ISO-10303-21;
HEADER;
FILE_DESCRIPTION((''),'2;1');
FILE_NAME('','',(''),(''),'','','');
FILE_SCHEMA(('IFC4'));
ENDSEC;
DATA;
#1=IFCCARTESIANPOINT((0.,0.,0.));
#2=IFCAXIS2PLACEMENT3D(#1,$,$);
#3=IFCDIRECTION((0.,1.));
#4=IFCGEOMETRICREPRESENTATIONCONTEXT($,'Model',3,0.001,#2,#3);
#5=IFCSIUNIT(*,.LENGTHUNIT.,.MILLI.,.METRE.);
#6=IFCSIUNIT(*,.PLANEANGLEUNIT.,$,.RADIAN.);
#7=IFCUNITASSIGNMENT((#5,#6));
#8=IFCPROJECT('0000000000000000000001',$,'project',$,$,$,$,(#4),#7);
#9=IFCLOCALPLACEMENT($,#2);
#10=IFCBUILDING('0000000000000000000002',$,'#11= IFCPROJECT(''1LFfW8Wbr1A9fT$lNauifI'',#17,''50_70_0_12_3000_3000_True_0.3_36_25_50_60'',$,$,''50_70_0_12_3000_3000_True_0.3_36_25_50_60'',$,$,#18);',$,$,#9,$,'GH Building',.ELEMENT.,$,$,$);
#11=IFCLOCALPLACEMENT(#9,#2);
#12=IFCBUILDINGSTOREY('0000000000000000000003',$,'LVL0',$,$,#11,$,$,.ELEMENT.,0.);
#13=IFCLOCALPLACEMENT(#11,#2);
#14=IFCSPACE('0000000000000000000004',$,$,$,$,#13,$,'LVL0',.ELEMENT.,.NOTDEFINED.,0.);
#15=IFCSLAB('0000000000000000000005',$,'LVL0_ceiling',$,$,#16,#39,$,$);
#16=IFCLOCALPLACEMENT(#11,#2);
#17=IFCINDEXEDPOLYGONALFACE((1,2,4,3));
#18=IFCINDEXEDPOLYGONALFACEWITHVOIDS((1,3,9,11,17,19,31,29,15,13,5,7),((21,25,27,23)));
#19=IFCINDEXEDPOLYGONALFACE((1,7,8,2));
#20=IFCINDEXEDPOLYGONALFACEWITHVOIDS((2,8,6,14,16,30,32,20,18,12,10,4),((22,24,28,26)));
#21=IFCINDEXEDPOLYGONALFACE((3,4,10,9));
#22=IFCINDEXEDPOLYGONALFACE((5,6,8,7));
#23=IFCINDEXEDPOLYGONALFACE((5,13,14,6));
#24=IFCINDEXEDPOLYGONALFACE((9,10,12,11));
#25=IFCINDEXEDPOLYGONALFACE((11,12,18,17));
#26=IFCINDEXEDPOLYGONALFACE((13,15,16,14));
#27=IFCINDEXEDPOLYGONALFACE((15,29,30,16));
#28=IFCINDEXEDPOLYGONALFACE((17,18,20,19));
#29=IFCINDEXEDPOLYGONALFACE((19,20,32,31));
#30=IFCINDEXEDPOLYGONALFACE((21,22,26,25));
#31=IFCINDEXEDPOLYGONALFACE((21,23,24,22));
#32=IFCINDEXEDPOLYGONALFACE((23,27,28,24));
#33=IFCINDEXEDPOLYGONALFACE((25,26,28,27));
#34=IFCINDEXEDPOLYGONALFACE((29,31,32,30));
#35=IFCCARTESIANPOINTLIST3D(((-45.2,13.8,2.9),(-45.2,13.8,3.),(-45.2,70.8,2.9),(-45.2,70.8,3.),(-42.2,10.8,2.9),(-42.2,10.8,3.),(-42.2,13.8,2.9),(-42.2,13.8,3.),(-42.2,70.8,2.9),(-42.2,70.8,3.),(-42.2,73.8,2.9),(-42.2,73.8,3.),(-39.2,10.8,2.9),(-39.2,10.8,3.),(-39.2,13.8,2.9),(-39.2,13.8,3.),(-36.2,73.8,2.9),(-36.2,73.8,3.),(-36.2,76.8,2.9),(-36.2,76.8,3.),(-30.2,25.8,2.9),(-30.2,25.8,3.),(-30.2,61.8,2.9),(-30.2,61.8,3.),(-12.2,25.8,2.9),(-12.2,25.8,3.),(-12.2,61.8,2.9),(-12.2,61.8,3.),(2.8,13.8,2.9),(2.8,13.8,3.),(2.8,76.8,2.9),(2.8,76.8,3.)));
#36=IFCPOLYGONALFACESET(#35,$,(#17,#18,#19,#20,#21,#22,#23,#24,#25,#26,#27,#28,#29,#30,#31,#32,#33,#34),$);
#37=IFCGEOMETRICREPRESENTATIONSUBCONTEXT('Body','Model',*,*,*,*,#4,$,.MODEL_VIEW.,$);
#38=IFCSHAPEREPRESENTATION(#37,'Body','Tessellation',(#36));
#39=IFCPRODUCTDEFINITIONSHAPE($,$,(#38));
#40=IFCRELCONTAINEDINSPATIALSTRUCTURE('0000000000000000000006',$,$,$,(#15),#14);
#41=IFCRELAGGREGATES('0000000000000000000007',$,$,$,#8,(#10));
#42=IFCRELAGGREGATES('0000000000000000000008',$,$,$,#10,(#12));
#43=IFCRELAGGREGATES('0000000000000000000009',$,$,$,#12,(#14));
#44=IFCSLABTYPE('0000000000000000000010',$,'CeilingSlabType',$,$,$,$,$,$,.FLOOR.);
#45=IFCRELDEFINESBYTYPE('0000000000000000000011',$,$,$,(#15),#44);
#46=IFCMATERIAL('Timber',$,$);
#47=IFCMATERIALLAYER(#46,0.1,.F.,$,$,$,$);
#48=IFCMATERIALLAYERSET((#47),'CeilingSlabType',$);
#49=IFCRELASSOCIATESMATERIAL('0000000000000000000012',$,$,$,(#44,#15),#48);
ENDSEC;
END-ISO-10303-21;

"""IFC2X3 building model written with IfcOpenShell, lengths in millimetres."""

from ifc_helpers import new_model, si_unit, direction, frame, origin, place, context, subcontext, project, spatial, polyline, outline, extrude, material, layer, layer_set, layer_usage, type_object, element, save


model = new_model("IFC2X3")

# Units and contexts
model_context = context("Model", 3, precision=0.001, world=origin(), true_north=direction((0.0, 1.0)))
body_context = subcontext(model_context, "Body", "Model", "MODEL_VIEW")
ifc_project = project(units=[si_unit("LENGTHUNIT", "METRE", prefix="MILLI"), si_unit("PLANEANGLEUNIT", "RADIAN")], contexts=[model_context])

# Building, storey, space
building_placement = place(None, origin())
building = spatial("IfcBuilding", under=ifc_project, at=building_placement, Name="#11= IFCPROJECT('1LFfW8Wbr1A9fT$lNauifI',#17,'50_70_0_12_3000_3000_True_0.3_36_25_50_60',$,$,'50_70_0_12_3000_3000_True_0.3_36_25_50_60',$,$,#18);", LongName="GH Building", CompositionType="ELEMENT")
storey_placement = place(building_placement, origin())
storey = spatial("IfcBuildingStorey", under=building, at=storey_placement, Name="LVL0", CompositionType="ELEMENT", Elevation=0.0)
space_placement = place(storey_placement, origin())
space = spatial("IfcSpace", under=storey, at=space_placement, LongName="LVL0", CompositionType="ELEMENT", InteriorOrExteriorSpace="NOTDEFINED", ElevationWithFlooring=0.0)

# Slab
ifc_material_1 = material(Name="Timber")
ifc_layer_1 = layer(ifc_material_1, 0.1, ventilated=False)
ifc_layer_set_1 = layer_set([ifc_layer_1], Name="CeilingSlabType")
ifc_layer_usage_1 = layer_usage(ifc_layer_set_1, "AXIS3", "NEGATIVE", -0.1)
slab_type = type_object("IfcSlabType", Name="CeilingSlabType", PredefinedType="FLOOR", material=ifc_layer_set_1)
slab_placement = place(space_placement, frame((-21.2, 43.8, 2.9)))
element("IfcSlab", 1, at=slab_placement, inside=space, type_object=slab_type, material=ifc_layer_usage_1, Name="LVL0_ceiling", context=body_context, shape_type="SweptSolid", body=[
    extrude(outline(polyline([(-21.0, 27.0), (-24.0, 27.0), (-24.0, -30.0), (-21.0, -30.0), (-21.0, -33.0), (-18.0, -33.0), (-18.0, -30.0), (24.0, -30.0), (24.0, 33.0), (-15.0, 33.0), (-15.0, 30.0), (-21.0, 30.0), (-21.0, 27.0)]), holes=[polyline([(-9.0, -18.0), (-9.0, 18.0), (9.0, 18.0), (9.0, -18.0), (-9.0, -18.0)])]), origin(), (0.0, 0.0, 1.0), 0.1),
])

save(model, "model.ifc")
